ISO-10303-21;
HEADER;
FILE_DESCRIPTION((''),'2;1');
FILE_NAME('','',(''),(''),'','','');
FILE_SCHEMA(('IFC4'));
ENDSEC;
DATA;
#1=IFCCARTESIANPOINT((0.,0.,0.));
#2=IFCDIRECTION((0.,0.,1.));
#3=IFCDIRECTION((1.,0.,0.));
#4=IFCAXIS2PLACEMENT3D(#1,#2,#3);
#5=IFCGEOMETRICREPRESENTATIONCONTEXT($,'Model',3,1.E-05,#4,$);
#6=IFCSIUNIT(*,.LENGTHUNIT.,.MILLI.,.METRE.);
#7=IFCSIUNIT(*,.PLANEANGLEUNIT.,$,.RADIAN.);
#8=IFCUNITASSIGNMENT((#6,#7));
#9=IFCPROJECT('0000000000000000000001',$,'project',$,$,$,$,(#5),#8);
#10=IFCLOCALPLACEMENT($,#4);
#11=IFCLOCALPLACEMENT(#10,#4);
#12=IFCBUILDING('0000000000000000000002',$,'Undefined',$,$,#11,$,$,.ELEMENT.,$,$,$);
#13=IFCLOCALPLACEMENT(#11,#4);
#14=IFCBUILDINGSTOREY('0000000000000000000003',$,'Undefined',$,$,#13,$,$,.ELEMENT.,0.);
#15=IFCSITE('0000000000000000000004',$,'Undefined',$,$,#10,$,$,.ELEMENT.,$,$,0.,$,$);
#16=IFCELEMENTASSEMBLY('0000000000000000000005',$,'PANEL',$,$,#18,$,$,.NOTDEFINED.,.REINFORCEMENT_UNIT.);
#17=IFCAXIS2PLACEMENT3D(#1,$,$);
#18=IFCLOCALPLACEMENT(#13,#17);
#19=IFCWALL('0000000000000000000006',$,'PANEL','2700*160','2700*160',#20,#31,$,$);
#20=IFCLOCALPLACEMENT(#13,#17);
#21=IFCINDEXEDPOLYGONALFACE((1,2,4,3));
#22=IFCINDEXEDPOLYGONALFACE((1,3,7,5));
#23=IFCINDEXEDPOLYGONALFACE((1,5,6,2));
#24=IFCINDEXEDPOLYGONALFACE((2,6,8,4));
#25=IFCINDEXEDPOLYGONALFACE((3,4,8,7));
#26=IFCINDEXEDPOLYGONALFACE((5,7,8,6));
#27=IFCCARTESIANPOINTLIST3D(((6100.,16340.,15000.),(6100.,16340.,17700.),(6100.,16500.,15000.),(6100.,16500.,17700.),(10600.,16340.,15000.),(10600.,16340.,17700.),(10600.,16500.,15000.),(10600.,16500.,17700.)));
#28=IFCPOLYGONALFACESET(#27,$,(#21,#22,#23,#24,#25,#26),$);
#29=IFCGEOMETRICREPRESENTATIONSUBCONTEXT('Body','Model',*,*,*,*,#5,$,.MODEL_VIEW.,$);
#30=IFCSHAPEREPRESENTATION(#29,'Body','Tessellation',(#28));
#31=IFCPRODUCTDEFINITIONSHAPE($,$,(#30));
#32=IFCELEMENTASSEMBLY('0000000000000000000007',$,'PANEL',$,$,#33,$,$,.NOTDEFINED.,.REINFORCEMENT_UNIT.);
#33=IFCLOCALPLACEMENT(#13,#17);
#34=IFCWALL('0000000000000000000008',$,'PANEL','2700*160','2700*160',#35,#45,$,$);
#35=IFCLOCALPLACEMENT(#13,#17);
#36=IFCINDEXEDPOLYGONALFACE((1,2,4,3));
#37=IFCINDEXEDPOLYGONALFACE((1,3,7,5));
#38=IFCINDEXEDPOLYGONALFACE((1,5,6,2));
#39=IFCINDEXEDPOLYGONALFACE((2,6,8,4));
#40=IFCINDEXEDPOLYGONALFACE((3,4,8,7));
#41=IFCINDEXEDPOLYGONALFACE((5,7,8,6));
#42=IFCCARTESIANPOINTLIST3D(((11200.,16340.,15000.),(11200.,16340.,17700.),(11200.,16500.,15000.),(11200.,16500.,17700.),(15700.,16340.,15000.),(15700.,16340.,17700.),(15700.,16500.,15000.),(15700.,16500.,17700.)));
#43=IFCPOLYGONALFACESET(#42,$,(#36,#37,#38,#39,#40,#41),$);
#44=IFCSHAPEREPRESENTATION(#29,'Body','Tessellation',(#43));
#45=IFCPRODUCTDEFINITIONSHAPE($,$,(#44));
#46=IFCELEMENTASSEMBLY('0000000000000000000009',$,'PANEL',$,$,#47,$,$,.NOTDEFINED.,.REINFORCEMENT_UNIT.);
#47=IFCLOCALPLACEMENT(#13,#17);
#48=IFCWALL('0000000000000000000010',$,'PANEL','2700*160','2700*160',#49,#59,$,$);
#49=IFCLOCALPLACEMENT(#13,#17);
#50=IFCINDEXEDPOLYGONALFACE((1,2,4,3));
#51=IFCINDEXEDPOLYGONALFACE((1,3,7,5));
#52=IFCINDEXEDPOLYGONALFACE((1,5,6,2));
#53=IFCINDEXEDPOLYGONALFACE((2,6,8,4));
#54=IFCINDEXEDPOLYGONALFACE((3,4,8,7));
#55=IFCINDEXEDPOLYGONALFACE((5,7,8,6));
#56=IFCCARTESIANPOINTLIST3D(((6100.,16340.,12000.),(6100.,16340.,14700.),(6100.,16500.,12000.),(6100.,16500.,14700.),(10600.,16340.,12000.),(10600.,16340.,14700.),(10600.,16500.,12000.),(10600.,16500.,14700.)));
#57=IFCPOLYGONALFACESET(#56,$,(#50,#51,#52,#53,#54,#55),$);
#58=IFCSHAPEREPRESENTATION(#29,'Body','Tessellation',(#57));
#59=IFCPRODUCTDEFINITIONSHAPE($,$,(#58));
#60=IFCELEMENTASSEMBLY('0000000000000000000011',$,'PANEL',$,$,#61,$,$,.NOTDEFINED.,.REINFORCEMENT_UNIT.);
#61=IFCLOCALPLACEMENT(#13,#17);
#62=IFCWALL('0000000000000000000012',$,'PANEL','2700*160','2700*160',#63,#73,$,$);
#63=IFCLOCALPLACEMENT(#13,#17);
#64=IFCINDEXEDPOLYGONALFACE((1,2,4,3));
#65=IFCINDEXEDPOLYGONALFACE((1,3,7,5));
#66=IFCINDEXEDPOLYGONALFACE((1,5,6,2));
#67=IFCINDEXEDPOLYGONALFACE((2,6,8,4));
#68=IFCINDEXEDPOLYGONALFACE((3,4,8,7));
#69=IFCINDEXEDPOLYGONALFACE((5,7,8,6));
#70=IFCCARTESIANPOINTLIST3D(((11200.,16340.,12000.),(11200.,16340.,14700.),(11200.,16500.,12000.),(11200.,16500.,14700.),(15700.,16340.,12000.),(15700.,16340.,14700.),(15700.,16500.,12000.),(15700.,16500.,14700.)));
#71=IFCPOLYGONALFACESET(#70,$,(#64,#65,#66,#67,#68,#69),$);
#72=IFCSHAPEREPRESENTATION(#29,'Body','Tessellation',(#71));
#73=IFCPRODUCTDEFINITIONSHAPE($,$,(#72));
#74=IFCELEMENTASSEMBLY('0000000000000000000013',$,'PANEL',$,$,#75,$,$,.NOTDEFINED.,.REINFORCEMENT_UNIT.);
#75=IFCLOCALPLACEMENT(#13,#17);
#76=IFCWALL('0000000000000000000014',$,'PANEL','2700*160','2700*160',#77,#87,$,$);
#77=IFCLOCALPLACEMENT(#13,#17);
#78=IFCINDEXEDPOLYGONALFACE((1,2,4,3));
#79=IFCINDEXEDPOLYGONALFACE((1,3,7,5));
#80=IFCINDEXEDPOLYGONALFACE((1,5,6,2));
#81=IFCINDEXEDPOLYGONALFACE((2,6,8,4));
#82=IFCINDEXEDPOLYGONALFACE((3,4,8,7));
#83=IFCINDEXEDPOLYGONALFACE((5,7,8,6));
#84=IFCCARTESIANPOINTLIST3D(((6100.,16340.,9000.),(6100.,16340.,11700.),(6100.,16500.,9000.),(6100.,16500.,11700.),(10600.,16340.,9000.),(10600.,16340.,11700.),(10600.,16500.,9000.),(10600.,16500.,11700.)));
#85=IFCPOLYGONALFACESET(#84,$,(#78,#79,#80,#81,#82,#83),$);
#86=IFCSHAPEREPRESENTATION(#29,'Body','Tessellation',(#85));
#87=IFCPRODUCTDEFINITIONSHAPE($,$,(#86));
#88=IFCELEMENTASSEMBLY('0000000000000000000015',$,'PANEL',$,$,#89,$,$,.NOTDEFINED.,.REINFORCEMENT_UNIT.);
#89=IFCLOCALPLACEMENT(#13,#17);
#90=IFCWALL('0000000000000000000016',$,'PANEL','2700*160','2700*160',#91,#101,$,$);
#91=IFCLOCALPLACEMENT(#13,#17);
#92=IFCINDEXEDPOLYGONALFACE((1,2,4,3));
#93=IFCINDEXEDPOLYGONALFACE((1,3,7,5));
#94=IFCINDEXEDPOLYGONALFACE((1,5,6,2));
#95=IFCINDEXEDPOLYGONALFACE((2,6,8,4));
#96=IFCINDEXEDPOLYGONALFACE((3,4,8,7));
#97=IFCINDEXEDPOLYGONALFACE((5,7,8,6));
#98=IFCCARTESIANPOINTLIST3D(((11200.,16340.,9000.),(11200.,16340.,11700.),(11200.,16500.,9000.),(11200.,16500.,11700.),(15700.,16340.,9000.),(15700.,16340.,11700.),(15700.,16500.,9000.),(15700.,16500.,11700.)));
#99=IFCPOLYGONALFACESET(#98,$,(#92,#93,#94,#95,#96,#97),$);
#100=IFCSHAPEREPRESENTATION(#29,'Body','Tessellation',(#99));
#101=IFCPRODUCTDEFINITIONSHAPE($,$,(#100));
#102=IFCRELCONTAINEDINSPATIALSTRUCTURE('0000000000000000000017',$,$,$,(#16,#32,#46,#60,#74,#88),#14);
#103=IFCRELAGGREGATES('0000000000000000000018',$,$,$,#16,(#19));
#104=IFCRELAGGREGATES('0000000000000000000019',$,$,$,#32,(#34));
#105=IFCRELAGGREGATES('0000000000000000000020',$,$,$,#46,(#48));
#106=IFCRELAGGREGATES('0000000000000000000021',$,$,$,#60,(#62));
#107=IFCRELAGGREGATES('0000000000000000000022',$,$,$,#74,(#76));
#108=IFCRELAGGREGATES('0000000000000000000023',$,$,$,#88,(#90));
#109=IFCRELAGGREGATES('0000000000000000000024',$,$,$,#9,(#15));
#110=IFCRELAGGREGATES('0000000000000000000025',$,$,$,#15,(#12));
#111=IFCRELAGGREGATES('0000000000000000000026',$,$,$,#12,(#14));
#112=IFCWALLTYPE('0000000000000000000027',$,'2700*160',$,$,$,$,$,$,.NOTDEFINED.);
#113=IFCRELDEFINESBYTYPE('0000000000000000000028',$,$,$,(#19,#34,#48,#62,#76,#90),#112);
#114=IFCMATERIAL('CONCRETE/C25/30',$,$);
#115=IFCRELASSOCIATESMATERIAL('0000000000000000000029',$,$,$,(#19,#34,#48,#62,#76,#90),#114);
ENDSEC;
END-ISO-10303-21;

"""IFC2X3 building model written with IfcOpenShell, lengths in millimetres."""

from ifc_helpers import new_model, si_unit, frame, frame_2d, origin_with_axes, place, context, subcontext, project, spatial, rectangle, extrude, material, type_object, element, aggregate, save


model = new_model("IFC2X3")

# Units and contexts
model_context = context("Model", 3, precision=1e-05, world=origin_with_axes())
body_context = subcontext(model_context, "Body", "Model", "MODEL_VIEW")
ifc_project = project(units=[si_unit("LENGTHUNIT", "METRE", prefix="MILLI"), si_unit("PLANEANGLEUNIT", "RADIAN")], contexts=[model_context])

# Site, building, storey
site_placement = place(None, origin_with_axes())
site = spatial("IfcSite", under=ifc_project, at=site_placement, Name="Undefined", CompositionType="ELEMENT", RefElevation=0.0)
building_placement = place(site_placement, origin_with_axes())
building = spatial("IfcBuilding", under=site, at=building_placement, Name="Undefined", CompositionType="ELEMENT")
storey_placement = place(building_placement, origin_with_axes())
storey = spatial("IfcBuildingStorey", under=building, at=storey_placement, Name="Undefined", CompositionType="ELEMENT", Elevation=0.0)

# Shared definitions
ifc_material = material(Name="CONCRETE/C25/30")

# Element assemblies, walls
assembly_1_placement = place(storey_placement, origin_with_axes())
assembly_1 = element("IfcElementAssembly", 1, at=assembly_1_placement, inside=storey, Name="PANEL", AssemblyPlace="NOTDEFINED", PredefinedType="REINFORCEMENT_UNIT")
wall_type = type_object("IfcWallType", Name="2700*160", PredefinedType="NOTDEFINED")
wall_1_placement = place(assembly_1_placement, frame((6100.0, 16420.0, 15000.0), z_axis=(0.0, 0.0, 1.0), x_axis=(1.0, 0.0, 0.0)))
wall_1 = element("IfcWall", 2, at=wall_1_placement, type_object=wall_type, material=ifc_material, Name="PANEL", Description="2700*160", ObjectType="2700*160", context=body_context, shape_type="SweptSolid", body=[
    extrude(rectangle(XDim=4500.0, YDim=160.0, at=frame_2d((0.0, 2250.0), x_axis=(0.0, -1.0))), frame((0.0, 0.0, 0.0), z_axis=(0.0, 0.0, 1.0), x_axis=(0.0, -1.0, 0.0)), (0.0, 0.0, 1.0), 2700.0),
])
aggregate(assembly_1, [wall_1])
assembly_2_placement = place(storey_placement, origin_with_axes())
assembly_2 = element("IfcElementAssembly", 3, at=assembly_2_placement, inside=storey, Name="PANEL", AssemblyPlace="NOTDEFINED", PredefinedType="REINFORCEMENT_UNIT")
wall_2_placement = place(assembly_2_placement, frame((11200.0, 16420.0, 15000.0), z_axis=(0.0, 0.0, 1.0), x_axis=(1.0, 0.0, 0.0)))
wall_2 = element("IfcWall", 4, at=wall_2_placement, type_object=wall_type, material=ifc_material, Name="PANEL", Description="2700*160", ObjectType="2700*160", context=body_context, shape_type="SweptSolid", body=[
    extrude(rectangle(XDim=4500.0, YDim=160.0, at=frame_2d((0.0, 2250.0), x_axis=(0.0, -1.0))), frame((0.0, 0.0, 0.0), z_axis=(0.0, 0.0, 1.0), x_axis=(0.0, -1.0, 0.0)), (0.0, 0.0, 1.0), 2700.0),
])
aggregate(assembly_2, [wall_2])
assembly_3_placement = place(storey_placement, origin_with_axes())
assembly_3 = element("IfcElementAssembly", 5, at=assembly_3_placement, inside=storey, Name="PANEL", AssemblyPlace="NOTDEFINED", PredefinedType="REINFORCEMENT_UNIT")
wall_3_placement = place(assembly_3_placement, frame((6100.0, 16420.0, 12000.0), z_axis=(0.0, 0.0, 1.0), x_axis=(1.0, 0.0, 0.0)))
wall_3 = element("IfcWall", 6, at=wall_3_placement, type_object=wall_type, material=ifc_material, Name="PANEL", Description="2700*160", ObjectType="2700*160", context=body_context, shape_type="SweptSolid", body=[
    extrude(rectangle(XDim=4500.0, YDim=160.0, at=frame_2d((0.0, 2250.0), x_axis=(0.0, -1.0))), frame((0.0, 0.0, 0.0), z_axis=(0.0, 0.0, 1.0), x_axis=(0.0, -1.0, 0.0)), (0.0, 0.0, 1.0), 2700.0),
])
aggregate(assembly_3, [wall_3])
assembly_4_placement = place(storey_placement, origin_with_axes())
assembly_4 = element("IfcElementAssembly", 7, at=assembly_4_placement, inside=storey, Name="PANEL", AssemblyPlace="NOTDEFINED", PredefinedType="REINFORCEMENT_UNIT")
wall_4_placement = place(assembly_4_placement, frame((11200.0, 16420.0, 12000.0), z_axis=(0.0, 0.0, 1.0), x_axis=(1.0, 0.0, 0.0)))
wall_4 = element("IfcWall", 8, at=wall_4_placement, type_object=wall_type, material=ifc_material, Name="PANEL", Description="2700*160", ObjectType="2700*160", context=body_context, shape_type="SweptSolid", body=[
    extrude(rectangle(XDim=4500.0, YDim=160.0, at=frame_2d((0.0, 2250.0), x_axis=(0.0, -1.0))), frame((0.0, 0.0, 0.0), z_axis=(0.0, 0.0, 1.0), x_axis=(0.0, -1.0, 0.0)), (0.0, 0.0, 1.0), 2700.0),
])
aggregate(assembly_4, [wall_4])
assembly_5_placement = place(storey_placement, origin_with_axes())
assembly_5 = element("IfcElementAssembly", 9, at=assembly_5_placement, inside=storey, Name="PANEL", AssemblyPlace="NOTDEFINED", PredefinedType="REINFORCEMENT_UNIT")
wall_5_placement = place(assembly_5_placement, frame((6100.0, 16420.0, 9000.0), z_axis=(0.0, 0.0, 1.0), x_axis=(1.0, 0.0, 0.0)))
wall_5 = element("IfcWall", 10, at=wall_5_placement, type_object=wall_type, material=ifc_material, Name="PANEL", Description="2700*160", ObjectType="2700*160", context=body_context, shape_type="SweptSolid", body=[
    extrude(rectangle(XDim=4500.0, YDim=160.0, at=frame_2d((0.0, 2250.0), x_axis=(0.0, -1.0))), frame((0.0, 0.0, 0.0), z_axis=(0.0, 0.0, 1.0), x_axis=(0.0, -1.0, 0.0)), (0.0, 0.0, 1.0), 2700.0),
])
aggregate(assembly_5, [wall_5])
assembly_6_placement = place(storey_placement, origin_with_axes())
assembly_6 = element("IfcElementAssembly", 11, at=assembly_6_placement, inside=storey, Name="PANEL", AssemblyPlace="NOTDEFINED", PredefinedType="REINFORCEMENT_UNIT")
wall_6_placement = place(assembly_6_placement, frame((11200.0, 16420.0, 9000.0), z_axis=(0.0, 0.0, 1.0), x_axis=(1.0, 0.0, 0.0)))
wall_6 = element("IfcWall", 12, at=wall_6_placement, type_object=wall_type, material=ifc_material, Name="PANEL", Description="2700*160", ObjectType="2700*160", context=body_context, shape_type="SweptSolid", body=[
    extrude(rectangle(XDim=4500.0, YDim=160.0, at=frame_2d((0.0, 2250.0), x_axis=(0.0, -1.0))), frame((0.0, 0.0, 0.0), z_axis=(0.0, 0.0, 1.0), x_axis=(0.0, -1.0, 0.0)), (0.0, 0.0, 1.0), 2700.0),
])
aggregate(assembly_6, [wall_6])

save(model, "model.ifc")
